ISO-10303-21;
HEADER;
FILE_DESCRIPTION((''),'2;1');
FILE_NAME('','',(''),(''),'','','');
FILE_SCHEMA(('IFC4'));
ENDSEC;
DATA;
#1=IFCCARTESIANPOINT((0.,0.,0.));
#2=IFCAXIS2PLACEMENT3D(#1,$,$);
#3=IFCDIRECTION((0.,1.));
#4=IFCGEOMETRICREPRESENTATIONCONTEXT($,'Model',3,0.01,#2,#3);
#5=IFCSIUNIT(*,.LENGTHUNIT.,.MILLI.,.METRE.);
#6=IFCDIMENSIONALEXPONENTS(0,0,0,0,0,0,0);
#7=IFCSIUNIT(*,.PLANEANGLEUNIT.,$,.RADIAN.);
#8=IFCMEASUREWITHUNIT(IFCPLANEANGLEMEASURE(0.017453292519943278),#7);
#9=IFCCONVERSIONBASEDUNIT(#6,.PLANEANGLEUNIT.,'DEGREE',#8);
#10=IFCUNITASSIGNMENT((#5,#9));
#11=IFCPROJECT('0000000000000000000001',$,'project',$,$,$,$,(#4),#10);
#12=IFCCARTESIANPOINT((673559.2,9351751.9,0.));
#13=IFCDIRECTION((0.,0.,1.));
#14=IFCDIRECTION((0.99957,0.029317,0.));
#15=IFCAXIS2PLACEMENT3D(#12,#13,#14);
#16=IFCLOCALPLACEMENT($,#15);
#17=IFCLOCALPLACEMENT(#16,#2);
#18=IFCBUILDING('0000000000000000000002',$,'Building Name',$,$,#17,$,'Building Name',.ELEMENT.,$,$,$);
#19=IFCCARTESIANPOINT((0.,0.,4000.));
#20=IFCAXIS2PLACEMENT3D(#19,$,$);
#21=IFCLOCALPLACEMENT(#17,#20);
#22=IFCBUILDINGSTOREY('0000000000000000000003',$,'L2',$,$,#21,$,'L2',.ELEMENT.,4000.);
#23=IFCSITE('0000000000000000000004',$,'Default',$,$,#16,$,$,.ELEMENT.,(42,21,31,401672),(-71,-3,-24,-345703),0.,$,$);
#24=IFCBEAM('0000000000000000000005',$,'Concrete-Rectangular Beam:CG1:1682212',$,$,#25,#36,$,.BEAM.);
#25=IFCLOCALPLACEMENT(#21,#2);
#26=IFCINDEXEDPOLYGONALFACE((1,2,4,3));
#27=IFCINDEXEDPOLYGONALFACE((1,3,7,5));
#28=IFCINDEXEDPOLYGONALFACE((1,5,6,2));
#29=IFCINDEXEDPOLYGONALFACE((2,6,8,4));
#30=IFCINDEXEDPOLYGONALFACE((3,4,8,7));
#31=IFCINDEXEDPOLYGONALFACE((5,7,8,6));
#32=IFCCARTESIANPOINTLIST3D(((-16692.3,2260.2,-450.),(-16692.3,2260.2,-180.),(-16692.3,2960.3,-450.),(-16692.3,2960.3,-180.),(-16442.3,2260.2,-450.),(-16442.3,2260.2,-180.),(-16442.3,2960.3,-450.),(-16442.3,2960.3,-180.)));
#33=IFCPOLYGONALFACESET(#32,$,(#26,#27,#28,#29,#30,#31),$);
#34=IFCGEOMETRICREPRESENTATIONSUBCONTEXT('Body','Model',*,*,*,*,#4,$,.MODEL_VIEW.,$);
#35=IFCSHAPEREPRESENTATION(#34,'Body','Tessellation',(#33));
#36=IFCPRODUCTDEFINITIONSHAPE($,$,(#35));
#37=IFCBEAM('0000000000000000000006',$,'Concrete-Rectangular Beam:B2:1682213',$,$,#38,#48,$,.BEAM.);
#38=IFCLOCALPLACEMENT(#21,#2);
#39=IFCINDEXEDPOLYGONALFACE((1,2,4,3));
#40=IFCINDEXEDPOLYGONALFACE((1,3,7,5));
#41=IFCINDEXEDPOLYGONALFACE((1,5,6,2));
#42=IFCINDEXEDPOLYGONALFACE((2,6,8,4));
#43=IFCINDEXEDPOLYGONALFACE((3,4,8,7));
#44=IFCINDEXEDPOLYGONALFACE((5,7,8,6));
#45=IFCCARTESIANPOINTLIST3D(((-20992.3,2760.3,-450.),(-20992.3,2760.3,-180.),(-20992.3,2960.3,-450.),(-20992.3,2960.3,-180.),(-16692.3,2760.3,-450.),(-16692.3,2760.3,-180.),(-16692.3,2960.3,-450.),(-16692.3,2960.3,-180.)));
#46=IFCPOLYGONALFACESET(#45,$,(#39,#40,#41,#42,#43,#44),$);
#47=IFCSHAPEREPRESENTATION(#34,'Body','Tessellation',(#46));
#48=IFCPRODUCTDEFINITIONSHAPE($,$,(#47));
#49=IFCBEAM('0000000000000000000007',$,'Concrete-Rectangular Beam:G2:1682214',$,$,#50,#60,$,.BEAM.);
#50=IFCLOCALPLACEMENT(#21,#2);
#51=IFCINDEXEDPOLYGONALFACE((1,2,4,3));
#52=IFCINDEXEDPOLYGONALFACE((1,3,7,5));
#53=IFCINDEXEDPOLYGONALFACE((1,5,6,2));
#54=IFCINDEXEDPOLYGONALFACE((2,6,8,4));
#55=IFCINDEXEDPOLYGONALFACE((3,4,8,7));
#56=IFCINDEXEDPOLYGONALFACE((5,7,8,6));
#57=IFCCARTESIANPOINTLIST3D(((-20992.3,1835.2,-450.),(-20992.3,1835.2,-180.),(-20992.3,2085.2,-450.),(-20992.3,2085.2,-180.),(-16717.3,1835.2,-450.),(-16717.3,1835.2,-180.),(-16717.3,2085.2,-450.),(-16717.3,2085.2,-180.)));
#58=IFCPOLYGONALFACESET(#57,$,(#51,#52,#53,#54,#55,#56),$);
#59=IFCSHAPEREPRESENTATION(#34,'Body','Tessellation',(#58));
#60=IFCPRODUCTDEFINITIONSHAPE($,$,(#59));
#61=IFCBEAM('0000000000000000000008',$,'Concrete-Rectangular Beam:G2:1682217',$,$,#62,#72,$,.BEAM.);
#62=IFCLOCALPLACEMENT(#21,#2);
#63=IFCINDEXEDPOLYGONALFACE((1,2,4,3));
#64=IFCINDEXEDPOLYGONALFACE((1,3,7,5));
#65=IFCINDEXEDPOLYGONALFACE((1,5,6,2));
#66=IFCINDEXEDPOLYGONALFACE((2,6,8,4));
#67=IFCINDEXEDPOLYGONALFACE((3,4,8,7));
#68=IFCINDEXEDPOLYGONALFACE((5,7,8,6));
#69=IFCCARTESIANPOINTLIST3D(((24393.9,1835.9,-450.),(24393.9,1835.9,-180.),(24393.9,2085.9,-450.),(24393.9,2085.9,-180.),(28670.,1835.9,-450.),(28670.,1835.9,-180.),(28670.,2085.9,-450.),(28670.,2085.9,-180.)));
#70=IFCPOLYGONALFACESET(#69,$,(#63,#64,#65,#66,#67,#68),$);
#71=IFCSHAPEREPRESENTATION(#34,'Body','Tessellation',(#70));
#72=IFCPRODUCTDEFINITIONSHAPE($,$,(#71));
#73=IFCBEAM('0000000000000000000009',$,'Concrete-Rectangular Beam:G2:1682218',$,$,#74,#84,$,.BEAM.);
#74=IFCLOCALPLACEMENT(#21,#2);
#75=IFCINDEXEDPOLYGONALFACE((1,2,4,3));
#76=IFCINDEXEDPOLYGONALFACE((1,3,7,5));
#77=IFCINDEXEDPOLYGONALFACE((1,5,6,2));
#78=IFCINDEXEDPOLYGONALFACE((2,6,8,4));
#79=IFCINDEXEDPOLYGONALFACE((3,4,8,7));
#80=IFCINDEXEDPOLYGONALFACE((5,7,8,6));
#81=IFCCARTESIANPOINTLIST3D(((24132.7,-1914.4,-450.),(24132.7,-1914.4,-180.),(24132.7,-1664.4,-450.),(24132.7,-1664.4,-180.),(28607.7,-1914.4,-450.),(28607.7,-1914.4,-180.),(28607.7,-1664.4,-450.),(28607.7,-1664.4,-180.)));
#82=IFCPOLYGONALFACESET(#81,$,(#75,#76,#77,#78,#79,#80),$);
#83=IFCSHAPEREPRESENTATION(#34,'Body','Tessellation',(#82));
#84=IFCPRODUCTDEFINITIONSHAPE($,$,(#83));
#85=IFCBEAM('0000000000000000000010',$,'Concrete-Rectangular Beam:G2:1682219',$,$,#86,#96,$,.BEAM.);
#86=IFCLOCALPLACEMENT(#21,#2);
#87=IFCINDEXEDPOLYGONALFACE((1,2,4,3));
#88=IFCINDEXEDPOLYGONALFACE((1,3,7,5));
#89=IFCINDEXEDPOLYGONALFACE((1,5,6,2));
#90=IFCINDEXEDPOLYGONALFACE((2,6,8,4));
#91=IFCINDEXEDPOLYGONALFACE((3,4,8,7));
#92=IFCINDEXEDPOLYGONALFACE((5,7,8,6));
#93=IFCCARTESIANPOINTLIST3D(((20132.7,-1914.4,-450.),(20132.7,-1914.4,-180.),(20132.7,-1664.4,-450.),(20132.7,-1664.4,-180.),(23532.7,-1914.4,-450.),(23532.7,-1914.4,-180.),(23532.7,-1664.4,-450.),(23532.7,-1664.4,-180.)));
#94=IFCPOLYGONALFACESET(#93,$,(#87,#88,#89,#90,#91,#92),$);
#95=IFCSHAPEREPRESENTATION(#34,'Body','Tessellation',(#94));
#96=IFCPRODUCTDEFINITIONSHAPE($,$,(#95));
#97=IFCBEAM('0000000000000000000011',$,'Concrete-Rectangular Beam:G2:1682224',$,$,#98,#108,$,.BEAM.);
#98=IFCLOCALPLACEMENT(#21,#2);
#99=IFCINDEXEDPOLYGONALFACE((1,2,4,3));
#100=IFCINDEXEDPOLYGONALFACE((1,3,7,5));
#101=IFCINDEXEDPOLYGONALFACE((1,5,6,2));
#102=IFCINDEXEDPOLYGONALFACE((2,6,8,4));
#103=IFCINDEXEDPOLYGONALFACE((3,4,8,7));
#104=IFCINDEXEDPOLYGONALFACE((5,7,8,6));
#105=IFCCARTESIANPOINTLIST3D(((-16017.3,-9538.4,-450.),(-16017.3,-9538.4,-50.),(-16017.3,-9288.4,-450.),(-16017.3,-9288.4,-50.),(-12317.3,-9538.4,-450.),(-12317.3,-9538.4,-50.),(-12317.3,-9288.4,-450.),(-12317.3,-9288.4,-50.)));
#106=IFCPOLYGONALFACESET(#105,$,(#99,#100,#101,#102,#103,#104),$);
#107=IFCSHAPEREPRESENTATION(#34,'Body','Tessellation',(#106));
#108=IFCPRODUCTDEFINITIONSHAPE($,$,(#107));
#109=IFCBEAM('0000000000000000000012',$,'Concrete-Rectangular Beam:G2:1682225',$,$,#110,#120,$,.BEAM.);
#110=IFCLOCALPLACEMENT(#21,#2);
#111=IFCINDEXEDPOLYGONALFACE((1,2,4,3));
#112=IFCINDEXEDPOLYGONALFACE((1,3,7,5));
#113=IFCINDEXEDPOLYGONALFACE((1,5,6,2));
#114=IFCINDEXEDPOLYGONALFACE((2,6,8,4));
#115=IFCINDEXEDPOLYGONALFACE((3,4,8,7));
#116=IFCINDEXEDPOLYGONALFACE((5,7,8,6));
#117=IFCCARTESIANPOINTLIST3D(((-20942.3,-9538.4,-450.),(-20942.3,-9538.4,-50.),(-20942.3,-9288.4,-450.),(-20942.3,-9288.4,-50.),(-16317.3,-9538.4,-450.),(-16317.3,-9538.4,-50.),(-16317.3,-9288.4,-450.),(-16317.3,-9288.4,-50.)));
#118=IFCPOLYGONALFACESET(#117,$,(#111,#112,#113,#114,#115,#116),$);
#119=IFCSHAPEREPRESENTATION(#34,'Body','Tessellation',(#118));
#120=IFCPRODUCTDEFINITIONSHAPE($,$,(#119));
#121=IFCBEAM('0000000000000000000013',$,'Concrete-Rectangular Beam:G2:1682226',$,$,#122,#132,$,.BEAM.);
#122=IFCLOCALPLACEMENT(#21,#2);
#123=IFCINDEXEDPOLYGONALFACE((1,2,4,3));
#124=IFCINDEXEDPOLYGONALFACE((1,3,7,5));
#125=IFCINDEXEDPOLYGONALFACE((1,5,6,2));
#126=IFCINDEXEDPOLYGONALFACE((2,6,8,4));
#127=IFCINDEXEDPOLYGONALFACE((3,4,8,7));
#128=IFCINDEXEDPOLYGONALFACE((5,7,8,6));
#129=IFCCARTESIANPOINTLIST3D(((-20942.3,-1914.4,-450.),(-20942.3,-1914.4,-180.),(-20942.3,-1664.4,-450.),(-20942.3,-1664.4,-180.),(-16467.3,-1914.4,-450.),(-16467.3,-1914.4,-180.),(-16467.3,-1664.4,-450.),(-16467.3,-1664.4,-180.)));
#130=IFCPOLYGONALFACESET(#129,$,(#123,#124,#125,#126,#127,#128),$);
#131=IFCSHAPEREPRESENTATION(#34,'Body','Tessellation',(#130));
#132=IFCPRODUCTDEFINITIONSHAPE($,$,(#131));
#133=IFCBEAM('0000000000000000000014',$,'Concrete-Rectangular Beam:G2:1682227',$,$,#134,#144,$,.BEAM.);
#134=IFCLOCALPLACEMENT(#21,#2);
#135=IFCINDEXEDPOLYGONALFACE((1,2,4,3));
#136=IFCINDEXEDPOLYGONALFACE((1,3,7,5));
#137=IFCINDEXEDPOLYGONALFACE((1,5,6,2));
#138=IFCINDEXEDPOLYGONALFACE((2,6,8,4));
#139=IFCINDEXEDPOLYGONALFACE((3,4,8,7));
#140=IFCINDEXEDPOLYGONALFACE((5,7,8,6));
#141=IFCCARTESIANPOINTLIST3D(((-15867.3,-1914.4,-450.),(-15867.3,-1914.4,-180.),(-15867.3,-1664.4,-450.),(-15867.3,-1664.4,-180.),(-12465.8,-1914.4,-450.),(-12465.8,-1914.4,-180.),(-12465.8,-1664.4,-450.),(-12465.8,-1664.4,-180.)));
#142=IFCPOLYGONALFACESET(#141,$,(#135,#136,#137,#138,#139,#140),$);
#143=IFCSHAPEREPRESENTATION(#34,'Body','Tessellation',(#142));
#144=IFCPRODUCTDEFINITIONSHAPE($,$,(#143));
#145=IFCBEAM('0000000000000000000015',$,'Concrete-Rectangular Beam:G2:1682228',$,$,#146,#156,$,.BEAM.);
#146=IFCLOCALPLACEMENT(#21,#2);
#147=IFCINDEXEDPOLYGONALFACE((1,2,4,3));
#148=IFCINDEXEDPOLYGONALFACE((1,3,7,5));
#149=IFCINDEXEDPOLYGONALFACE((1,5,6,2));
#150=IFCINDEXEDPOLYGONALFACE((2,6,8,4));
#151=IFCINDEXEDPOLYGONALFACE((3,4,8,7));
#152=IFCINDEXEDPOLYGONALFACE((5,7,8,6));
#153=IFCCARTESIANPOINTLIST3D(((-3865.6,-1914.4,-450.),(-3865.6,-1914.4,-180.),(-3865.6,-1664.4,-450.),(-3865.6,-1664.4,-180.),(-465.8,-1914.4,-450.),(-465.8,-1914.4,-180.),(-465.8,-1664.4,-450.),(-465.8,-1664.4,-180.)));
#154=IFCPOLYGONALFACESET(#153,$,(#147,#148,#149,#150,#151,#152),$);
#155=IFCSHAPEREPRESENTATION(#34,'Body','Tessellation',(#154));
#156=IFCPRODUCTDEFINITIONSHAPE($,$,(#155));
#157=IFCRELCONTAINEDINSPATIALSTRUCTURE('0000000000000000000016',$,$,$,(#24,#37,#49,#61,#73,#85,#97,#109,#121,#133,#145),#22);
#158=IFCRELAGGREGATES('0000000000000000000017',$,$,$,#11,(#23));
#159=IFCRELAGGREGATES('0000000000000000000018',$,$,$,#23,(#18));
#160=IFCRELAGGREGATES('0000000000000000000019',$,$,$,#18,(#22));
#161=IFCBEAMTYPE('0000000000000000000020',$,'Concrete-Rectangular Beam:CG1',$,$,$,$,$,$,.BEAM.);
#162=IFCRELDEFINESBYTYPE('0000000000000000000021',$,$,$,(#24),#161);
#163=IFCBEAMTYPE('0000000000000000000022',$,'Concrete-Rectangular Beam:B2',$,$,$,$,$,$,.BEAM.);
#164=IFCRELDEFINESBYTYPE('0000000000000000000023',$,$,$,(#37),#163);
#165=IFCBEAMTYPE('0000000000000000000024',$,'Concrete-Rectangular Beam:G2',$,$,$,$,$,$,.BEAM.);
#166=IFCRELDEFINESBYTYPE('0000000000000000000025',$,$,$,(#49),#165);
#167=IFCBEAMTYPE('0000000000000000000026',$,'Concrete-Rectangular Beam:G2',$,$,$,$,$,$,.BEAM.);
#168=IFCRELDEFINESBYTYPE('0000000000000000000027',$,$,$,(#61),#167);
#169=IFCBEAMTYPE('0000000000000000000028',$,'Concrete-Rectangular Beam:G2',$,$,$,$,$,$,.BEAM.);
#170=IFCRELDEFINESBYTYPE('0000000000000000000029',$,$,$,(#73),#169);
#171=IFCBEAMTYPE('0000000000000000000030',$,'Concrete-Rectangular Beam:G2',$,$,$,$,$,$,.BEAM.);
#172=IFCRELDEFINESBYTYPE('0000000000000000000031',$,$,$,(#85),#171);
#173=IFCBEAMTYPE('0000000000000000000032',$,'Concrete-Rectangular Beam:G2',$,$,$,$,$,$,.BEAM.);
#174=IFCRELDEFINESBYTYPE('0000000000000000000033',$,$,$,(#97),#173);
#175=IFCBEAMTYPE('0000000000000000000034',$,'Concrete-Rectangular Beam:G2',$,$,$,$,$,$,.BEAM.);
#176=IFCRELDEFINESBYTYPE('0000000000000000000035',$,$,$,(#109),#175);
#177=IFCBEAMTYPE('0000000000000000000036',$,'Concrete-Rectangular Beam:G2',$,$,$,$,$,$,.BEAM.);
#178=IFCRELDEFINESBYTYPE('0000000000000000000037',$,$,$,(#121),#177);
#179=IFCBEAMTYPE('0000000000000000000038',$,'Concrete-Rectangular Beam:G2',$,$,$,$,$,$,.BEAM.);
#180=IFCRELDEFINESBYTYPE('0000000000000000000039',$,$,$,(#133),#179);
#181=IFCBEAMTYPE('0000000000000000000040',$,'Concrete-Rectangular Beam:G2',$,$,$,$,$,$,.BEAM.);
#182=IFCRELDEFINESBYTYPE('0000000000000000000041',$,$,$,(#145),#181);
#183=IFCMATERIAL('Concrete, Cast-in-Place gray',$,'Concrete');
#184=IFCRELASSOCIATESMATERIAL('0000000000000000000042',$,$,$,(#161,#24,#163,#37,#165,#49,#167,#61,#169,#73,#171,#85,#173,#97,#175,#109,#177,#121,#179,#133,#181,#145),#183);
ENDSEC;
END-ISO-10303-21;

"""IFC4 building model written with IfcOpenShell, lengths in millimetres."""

from ifc_helpers import new_model, entity, si_unit, converted_unit, direction, frame, origin, place, context, subcontext, project, spatial, indexed_curve, outline, extrude, source, transform, mapped, material, type_object, type_shapes, element, save


model = new_model("IFC4")

# Units and contexts
model_context = context("Model", 3, precision=0.01, world=origin(), true_north=direction((0.0, 1.0)))
body_context = subcontext(model_context, "Body", "Model", "MODEL_VIEW")
ifc_project = project(units=[si_unit("LENGTHUNIT", "METRE", prefix="MILLI"), converted_unit("PLANEANGLEUNIT", "DEGREE", entity("IfcPlaneAngleMeasure", 0.017453292519943278), si_unit("PLANEANGLEUNIT", "RADIAN"), dimensions=[0, 0, 0, 0, 0, 0, 0])], contexts=[model_context])

# Site, building, storey
site_placement = place(None, frame((673559.2, 9351751.9, 0.0), z_axis=(0.0, 0.0, 1.0), x_axis=(0.99957, 0.029317, 0.0)))
site = spatial("IfcSite", under=ifc_project, at=site_placement, Name="Default", CompositionType="ELEMENT", RefLatitude=(42, 21, 31, 401672), RefLongitude=(-71, -3, -24, -345703), RefElevation=0.0)
building_placement = place(site_placement, origin())
building = spatial("IfcBuilding", under=site, at=building_placement, Name="Building Name", LongName="Building Name", CompositionType="ELEMENT")
storey_placement = place(building_placement, frame((0.0, 0.0, 4000.0)))
storey = spatial("IfcBuildingStorey", under=building, at=storey_placement, Name="L2", LongName="L2", CompositionType="ELEMENT", Elevation=4000.0)

# Beams
ifc_material = material(Name="Concrete, Cast-in-Place gray", Category="Concrete")
beam_type_1 = type_object("IfcBeamType", Name="Concrete-Rectangular Beam:CG1", PredefinedType="BEAM", material=ifc_material)
shared_shape_1 = source(origin(), body_context, "Body", "SweptSolid", [
    extrude(outline(indexed_curve([(-125.0, -135.0), (125.0, -135.0), (125.0, 135.0), (-125.0, 135.0), (-125.0, -135.0)], self_intersect=False)), frame((-16567.3, 2260.2, 3685.0), z_axis=(0.0, 1.0, 0.0), x_axis=(-1.0, 0.0, 0.0)), (0.0, 0.0, 1.0), 700.1),
])
type_shapes(beam_type_1, [shared_shape_1])
beam_1_placement = place(storey_placement, frame((0.0, 0.0, -4000.0)))
element("IfcBeam", 1, at=beam_1_placement, inside=storey, type_object=beam_type_1, material=ifc_material, Name="Concrete-Rectangular Beam:CG1:1682212", PredefinedType="BEAM", context=body_context, shape_type="MappedRepresentation", body=[
    mapped(shared_shape_1, transform((0.0, 0.0, 0.0), scale=1.0)),
])
beam_type_2 = type_object("IfcBeamType", Name="Concrete-Rectangular Beam:B2", PredefinedType="BEAM", material=ifc_material)
shared_shape_2 = source(origin(), body_context, "Body", "SweptSolid", [
    extrude(outline(indexed_curve([(-135.0, -100.0), (135.0, -100.0), (135.0, 100.0), (-135.0, 100.0), (-135.0, -100.0)], self_intersect=False)), frame((-20992.3, 2860.3, 3685.0), z_axis=(1.0, 0.0, 0.0), x_axis=(0.0, 0.0, -1.0)), (0.0, 0.0, 1.0), 4300.0),
])
type_shapes(beam_type_2, [shared_shape_2])
beam_2_placement = place(storey_placement, frame((0.0, 0.0, -4000.0)))
element("IfcBeam", 2, at=beam_2_placement, inside=storey, type_object=beam_type_2, material=ifc_material, Name="Concrete-Rectangular Beam:B2:1682213", PredefinedType="BEAM", context=body_context, shape_type="MappedRepresentation", body=[
    mapped(shared_shape_2, transform((0.0, 0.0, 0.0), scale=1.0)),
])
beam_type_3 = type_object("IfcBeamType", Name="Concrete-Rectangular Beam:G2", PredefinedType="BEAM", material=ifc_material)
shared_shape_3 = source(origin(), body_context, "Body", "SweptSolid", [
    extrude(outline(indexed_curve([(-135.0, -125.0), (135.0, -125.0), (135.0, 125.0), (-135.0, 125.0), (-135.0, -125.0)], self_intersect=False)), frame((-20992.3, 1960.2, 3685.0), z_axis=(1.0, 0.0, 0.0), x_axis=(0.0, 0.0, -1.0)), (0.0, 0.0, 1.0), 4275.0),
])
type_shapes(beam_type_3, [shared_shape_3])
beam_3_placement = place(storey_placement, frame((0.0, 0.0, -4000.0)))
element("IfcBeam", 3, at=beam_3_placement, inside=storey, type_object=beam_type_3, material=ifc_material, Name="Concrete-Rectangular Beam:G2:1682214", PredefinedType="BEAM", context=body_context, shape_type="MappedRepresentation", body=[
    mapped(shared_shape_3, transform((0.0, 0.0, 0.0), scale=1.0)),
])
beam_type_4 = type_object("IfcBeamType", Name="Concrete-Rectangular Beam:G2", PredefinedType="BEAM", material=ifc_material)
shared_shape_4 = source(origin(), body_context, "Body", "SweptSolid", [
    extrude(outline(indexed_curve([(-135.0, -125.0), (135.0, -125.0), (135.0, 125.0), (-135.0, 125.0), (-135.0, -125.0)], self_intersect=False)), frame((28670.0, 1960.9, 3685.0), z_axis=(-1.0, 0.0, 0.0), x_axis=(0.0, 0.0, -1.0)), (0.0, 0.0, 1.0), 4276.1),
])
type_shapes(beam_type_4, [shared_shape_4])
beam_4_placement = place(storey_placement, frame((0.0, 0.0, -4000.0)))
element("IfcBeam", 4, at=beam_4_placement, inside=storey, type_object=beam_type_4, material=ifc_material, Name="Concrete-Rectangular Beam:G2:1682217", PredefinedType="BEAM", context=body_context, shape_type="MappedRepresentation", body=[
    mapped(shared_shape_4, transform((0.0, 0.0, 0.0), scale=1.0)),
])
beam_type_5 = type_object("IfcBeamType", Name="Concrete-Rectangular Beam:G2", PredefinedType="BEAM", material=ifc_material)
shared_shape_5 = source(origin(), body_context, "Body", "SweptSolid", [
    extrude(outline(indexed_curve([(-135.0, -125.0), (135.0, -125.0), (135.0, 125.0), (-135.0, 125.0), (-135.0, -125.0)], self_intersect=False)), frame((28607.7, -1789.4, 3685.0), z_axis=(-1.0, 0.0, 0.0), x_axis=(0.0, 0.0, -1.0)), (0.0, 0.0, 1.0), 4475.0),
])
type_shapes(beam_type_5, [shared_shape_5])
beam_5_placement = place(storey_placement, frame((0.0, 0.0, -4000.0)))
element("IfcBeam", 5, at=beam_5_placement, inside=storey, type_object=beam_type_5, material=ifc_material, Name="Concrete-Rectangular Beam:G2:1682218", PredefinedType="BEAM", context=body_context, shape_type="MappedRepresentation", body=[
    mapped(shared_shape_5, transform((0.0, 0.0, 0.0), scale=1.0)),
])
beam_type_6 = type_object("IfcBeamType", Name="Concrete-Rectangular Beam:G2", PredefinedType="BEAM", material=ifc_material)
shared_shape_6 = source(origin(), body_context, "Body", "SweptSolid", [
    extrude(outline(indexed_curve([(-135.0, -125.0), (135.0, -125.0), (135.0, 125.0), (-135.0, 125.0), (-135.0, -125.0)], self_intersect=False)), frame((23532.7, -1789.4, 3685.0), z_axis=(-1.0, 0.0, 0.0), x_axis=(0.0, 0.0, -1.0)), (0.0, 0.0, 1.0), 3400.0),
])
type_shapes(beam_type_6, [shared_shape_6])
beam_6_placement = place(storey_placement, frame((0.0, 0.0, -4000.0)))
element("IfcBeam", 6, at=beam_6_placement, inside=storey, type_object=beam_type_6, material=ifc_material, Name="Concrete-Rectangular Beam:G2:1682219", PredefinedType="BEAM", context=body_context, shape_type="MappedRepresentation", body=[
    mapped(shared_shape_6, transform((0.0, 0.0, 0.0), scale=1.0)),
])
beam_type_7 = type_object("IfcBeamType", Name="Concrete-Rectangular Beam:G2", PredefinedType="BEAM", material=ifc_material)
shared_shape_7 = source(origin(), body_context, "Body", "SweptSolid", [
    extrude(outline(indexed_curve([(-200.0, -125.0), (200.0, -125.0), (200.0, 125.0), (-200.0, 125.0), (-200.0, -125.0)], self_intersect=False)), frame((-12317.3, -9413.4, 3750.0), z_axis=(-1.0, 0.0, 0.0), x_axis=(0.0, 0.0, -1.0)), (0.0, 0.0, 1.0), 3700.0),
])
type_shapes(beam_type_7, [shared_shape_7])
beam_7_placement = place(storey_placement, frame((0.0, 0.0, -4000.0)))
element("IfcBeam", 7, at=beam_7_placement, inside=storey, type_object=beam_type_7, material=ifc_material, Name="Concrete-Rectangular Beam:G2:1682224", PredefinedType="BEAM", context=body_context, shape_type="MappedRepresentation", body=[
    mapped(shared_shape_7, transform((0.0, 0.0, 0.0), scale=1.0)),
])
beam_type_8 = type_object("IfcBeamType", Name="Concrete-Rectangular Beam:G2", PredefinedType="BEAM", material=ifc_material)
shared_shape_8 = source(origin(), body_context, "Body", "SweptSolid", [
    extrude(outline(indexed_curve([(-200.0, -125.0), (200.0, -125.0), (200.0, 125.0), (-200.0, 125.0), (-200.0, -125.0)], self_intersect=False)), frame((-16317.3, -9413.4, 3750.0), z_axis=(-1.0, 0.0, 0.0), x_axis=(0.0, 0.0, -1.0)), (0.0, 0.0, 1.0), 4625.0),
])
type_shapes(beam_type_8, [shared_shape_8])
beam_8_placement = place(storey_placement, frame((0.0, 0.0, -4000.0)))
element("IfcBeam", 8, at=beam_8_placement, inside=storey, type_object=beam_type_8, material=ifc_material, Name="Concrete-Rectangular Beam:G2:1682225", PredefinedType="BEAM", context=body_context, shape_type="MappedRepresentation", body=[
    mapped(shared_shape_8, transform((0.0, 0.0, 0.0), scale=1.0)),
])
beam_type_9 = type_object("IfcBeamType", Name="Concrete-Rectangular Beam:G2", PredefinedType="BEAM", material=ifc_material)
shared_shape_9 = source(origin(), body_context, "Body", "SweptSolid", [
    extrude(outline(indexed_curve([(-135.0, -125.0), (135.0, -125.0), (135.0, 125.0), (-135.0, 125.0), (-135.0, -125.0)], self_intersect=False)), frame((-20942.3, -1789.4, 3685.0), z_axis=(1.0, 0.0, 0.0), x_axis=(0.0, 0.0, -1.0)), (0.0, 0.0, 1.0), 4475.0),
])
type_shapes(beam_type_9, [shared_shape_9])
beam_9_placement = place(storey_placement, frame((0.0, 0.0, -4000.0)))
element("IfcBeam", 9, at=beam_9_placement, inside=storey, type_object=beam_type_9, material=ifc_material, Name="Concrete-Rectangular Beam:G2:1682226", PredefinedType="BEAM", context=body_context, shape_type="MappedRepresentation", body=[
    mapped(shared_shape_9, transform((0.0, 0.0, 0.0), scale=1.0)),
])
beam_type_10 = type_object("IfcBeamType", Name="Concrete-Rectangular Beam:G2", PredefinedType="BEAM", material=ifc_material)
shared_shape_10 = source(origin(), body_context, "Body", "SweptSolid", [
    extrude(outline(indexed_curve([(-135.0, -125.0), (135.0, -125.0), (135.0, 125.0), (-135.0, 125.0), (-135.0, -125.0)], self_intersect=False)), frame((-15867.3, -1789.4, 3685.0), z_axis=(1.0, 0.0, 0.0), x_axis=(0.0, 0.0, -1.0)), (0.0, 0.0, 1.0), 3401.5),
])
type_shapes(beam_type_10, [shared_shape_10])
beam_10_placement = place(storey_placement, frame((0.0, 0.0, -4000.0)))
element("IfcBeam", 10, at=beam_10_placement, inside=storey, type_object=beam_type_10, material=ifc_material, Name="Concrete-Rectangular Beam:G2:1682227", PredefinedType="BEAM", context=body_context, shape_type="MappedRepresentation", body=[
    mapped(shared_shape_10, transform((0.0, 0.0, 0.0), scale=1.0)),
])
beam_type_11 = type_object("IfcBeamType", Name="Concrete-Rectangular Beam:G2", PredefinedType="BEAM", material=ifc_material)
shared_shape_11 = source(origin(), body_context, "Body", "SweptSolid", [
    extrude(outline(indexed_curve([(-135.0, -125.0), (135.0, -125.0), (135.0, 125.0), (-135.0, 125.0), (-135.0, -125.0)], self_intersect=False)), frame((-465.8, -1789.4, 3685.0), z_axis=(-1.0, 0.0, 0.0), x_axis=(0.0, 0.0, -1.0)), (0.0, 0.0, 1.0), 3399.7),
])
type_shapes(beam_type_11, [shared_shape_11])
beam_11_placement = place(storey_placement, frame((0.0, 0.0, -4000.0)))
element("IfcBeam", 11, at=beam_11_placement, inside=storey, type_object=beam_type_11, material=ifc_material, Name="Concrete-Rectangular Beam:G2:1682228", PredefinedType="BEAM", context=body_context, shape_type="MappedRepresentation", body=[
    mapped(shared_shape_11, transform((0.0, 0.0, 0.0), scale=1.0)),
])

save(model, "model.ifc")
